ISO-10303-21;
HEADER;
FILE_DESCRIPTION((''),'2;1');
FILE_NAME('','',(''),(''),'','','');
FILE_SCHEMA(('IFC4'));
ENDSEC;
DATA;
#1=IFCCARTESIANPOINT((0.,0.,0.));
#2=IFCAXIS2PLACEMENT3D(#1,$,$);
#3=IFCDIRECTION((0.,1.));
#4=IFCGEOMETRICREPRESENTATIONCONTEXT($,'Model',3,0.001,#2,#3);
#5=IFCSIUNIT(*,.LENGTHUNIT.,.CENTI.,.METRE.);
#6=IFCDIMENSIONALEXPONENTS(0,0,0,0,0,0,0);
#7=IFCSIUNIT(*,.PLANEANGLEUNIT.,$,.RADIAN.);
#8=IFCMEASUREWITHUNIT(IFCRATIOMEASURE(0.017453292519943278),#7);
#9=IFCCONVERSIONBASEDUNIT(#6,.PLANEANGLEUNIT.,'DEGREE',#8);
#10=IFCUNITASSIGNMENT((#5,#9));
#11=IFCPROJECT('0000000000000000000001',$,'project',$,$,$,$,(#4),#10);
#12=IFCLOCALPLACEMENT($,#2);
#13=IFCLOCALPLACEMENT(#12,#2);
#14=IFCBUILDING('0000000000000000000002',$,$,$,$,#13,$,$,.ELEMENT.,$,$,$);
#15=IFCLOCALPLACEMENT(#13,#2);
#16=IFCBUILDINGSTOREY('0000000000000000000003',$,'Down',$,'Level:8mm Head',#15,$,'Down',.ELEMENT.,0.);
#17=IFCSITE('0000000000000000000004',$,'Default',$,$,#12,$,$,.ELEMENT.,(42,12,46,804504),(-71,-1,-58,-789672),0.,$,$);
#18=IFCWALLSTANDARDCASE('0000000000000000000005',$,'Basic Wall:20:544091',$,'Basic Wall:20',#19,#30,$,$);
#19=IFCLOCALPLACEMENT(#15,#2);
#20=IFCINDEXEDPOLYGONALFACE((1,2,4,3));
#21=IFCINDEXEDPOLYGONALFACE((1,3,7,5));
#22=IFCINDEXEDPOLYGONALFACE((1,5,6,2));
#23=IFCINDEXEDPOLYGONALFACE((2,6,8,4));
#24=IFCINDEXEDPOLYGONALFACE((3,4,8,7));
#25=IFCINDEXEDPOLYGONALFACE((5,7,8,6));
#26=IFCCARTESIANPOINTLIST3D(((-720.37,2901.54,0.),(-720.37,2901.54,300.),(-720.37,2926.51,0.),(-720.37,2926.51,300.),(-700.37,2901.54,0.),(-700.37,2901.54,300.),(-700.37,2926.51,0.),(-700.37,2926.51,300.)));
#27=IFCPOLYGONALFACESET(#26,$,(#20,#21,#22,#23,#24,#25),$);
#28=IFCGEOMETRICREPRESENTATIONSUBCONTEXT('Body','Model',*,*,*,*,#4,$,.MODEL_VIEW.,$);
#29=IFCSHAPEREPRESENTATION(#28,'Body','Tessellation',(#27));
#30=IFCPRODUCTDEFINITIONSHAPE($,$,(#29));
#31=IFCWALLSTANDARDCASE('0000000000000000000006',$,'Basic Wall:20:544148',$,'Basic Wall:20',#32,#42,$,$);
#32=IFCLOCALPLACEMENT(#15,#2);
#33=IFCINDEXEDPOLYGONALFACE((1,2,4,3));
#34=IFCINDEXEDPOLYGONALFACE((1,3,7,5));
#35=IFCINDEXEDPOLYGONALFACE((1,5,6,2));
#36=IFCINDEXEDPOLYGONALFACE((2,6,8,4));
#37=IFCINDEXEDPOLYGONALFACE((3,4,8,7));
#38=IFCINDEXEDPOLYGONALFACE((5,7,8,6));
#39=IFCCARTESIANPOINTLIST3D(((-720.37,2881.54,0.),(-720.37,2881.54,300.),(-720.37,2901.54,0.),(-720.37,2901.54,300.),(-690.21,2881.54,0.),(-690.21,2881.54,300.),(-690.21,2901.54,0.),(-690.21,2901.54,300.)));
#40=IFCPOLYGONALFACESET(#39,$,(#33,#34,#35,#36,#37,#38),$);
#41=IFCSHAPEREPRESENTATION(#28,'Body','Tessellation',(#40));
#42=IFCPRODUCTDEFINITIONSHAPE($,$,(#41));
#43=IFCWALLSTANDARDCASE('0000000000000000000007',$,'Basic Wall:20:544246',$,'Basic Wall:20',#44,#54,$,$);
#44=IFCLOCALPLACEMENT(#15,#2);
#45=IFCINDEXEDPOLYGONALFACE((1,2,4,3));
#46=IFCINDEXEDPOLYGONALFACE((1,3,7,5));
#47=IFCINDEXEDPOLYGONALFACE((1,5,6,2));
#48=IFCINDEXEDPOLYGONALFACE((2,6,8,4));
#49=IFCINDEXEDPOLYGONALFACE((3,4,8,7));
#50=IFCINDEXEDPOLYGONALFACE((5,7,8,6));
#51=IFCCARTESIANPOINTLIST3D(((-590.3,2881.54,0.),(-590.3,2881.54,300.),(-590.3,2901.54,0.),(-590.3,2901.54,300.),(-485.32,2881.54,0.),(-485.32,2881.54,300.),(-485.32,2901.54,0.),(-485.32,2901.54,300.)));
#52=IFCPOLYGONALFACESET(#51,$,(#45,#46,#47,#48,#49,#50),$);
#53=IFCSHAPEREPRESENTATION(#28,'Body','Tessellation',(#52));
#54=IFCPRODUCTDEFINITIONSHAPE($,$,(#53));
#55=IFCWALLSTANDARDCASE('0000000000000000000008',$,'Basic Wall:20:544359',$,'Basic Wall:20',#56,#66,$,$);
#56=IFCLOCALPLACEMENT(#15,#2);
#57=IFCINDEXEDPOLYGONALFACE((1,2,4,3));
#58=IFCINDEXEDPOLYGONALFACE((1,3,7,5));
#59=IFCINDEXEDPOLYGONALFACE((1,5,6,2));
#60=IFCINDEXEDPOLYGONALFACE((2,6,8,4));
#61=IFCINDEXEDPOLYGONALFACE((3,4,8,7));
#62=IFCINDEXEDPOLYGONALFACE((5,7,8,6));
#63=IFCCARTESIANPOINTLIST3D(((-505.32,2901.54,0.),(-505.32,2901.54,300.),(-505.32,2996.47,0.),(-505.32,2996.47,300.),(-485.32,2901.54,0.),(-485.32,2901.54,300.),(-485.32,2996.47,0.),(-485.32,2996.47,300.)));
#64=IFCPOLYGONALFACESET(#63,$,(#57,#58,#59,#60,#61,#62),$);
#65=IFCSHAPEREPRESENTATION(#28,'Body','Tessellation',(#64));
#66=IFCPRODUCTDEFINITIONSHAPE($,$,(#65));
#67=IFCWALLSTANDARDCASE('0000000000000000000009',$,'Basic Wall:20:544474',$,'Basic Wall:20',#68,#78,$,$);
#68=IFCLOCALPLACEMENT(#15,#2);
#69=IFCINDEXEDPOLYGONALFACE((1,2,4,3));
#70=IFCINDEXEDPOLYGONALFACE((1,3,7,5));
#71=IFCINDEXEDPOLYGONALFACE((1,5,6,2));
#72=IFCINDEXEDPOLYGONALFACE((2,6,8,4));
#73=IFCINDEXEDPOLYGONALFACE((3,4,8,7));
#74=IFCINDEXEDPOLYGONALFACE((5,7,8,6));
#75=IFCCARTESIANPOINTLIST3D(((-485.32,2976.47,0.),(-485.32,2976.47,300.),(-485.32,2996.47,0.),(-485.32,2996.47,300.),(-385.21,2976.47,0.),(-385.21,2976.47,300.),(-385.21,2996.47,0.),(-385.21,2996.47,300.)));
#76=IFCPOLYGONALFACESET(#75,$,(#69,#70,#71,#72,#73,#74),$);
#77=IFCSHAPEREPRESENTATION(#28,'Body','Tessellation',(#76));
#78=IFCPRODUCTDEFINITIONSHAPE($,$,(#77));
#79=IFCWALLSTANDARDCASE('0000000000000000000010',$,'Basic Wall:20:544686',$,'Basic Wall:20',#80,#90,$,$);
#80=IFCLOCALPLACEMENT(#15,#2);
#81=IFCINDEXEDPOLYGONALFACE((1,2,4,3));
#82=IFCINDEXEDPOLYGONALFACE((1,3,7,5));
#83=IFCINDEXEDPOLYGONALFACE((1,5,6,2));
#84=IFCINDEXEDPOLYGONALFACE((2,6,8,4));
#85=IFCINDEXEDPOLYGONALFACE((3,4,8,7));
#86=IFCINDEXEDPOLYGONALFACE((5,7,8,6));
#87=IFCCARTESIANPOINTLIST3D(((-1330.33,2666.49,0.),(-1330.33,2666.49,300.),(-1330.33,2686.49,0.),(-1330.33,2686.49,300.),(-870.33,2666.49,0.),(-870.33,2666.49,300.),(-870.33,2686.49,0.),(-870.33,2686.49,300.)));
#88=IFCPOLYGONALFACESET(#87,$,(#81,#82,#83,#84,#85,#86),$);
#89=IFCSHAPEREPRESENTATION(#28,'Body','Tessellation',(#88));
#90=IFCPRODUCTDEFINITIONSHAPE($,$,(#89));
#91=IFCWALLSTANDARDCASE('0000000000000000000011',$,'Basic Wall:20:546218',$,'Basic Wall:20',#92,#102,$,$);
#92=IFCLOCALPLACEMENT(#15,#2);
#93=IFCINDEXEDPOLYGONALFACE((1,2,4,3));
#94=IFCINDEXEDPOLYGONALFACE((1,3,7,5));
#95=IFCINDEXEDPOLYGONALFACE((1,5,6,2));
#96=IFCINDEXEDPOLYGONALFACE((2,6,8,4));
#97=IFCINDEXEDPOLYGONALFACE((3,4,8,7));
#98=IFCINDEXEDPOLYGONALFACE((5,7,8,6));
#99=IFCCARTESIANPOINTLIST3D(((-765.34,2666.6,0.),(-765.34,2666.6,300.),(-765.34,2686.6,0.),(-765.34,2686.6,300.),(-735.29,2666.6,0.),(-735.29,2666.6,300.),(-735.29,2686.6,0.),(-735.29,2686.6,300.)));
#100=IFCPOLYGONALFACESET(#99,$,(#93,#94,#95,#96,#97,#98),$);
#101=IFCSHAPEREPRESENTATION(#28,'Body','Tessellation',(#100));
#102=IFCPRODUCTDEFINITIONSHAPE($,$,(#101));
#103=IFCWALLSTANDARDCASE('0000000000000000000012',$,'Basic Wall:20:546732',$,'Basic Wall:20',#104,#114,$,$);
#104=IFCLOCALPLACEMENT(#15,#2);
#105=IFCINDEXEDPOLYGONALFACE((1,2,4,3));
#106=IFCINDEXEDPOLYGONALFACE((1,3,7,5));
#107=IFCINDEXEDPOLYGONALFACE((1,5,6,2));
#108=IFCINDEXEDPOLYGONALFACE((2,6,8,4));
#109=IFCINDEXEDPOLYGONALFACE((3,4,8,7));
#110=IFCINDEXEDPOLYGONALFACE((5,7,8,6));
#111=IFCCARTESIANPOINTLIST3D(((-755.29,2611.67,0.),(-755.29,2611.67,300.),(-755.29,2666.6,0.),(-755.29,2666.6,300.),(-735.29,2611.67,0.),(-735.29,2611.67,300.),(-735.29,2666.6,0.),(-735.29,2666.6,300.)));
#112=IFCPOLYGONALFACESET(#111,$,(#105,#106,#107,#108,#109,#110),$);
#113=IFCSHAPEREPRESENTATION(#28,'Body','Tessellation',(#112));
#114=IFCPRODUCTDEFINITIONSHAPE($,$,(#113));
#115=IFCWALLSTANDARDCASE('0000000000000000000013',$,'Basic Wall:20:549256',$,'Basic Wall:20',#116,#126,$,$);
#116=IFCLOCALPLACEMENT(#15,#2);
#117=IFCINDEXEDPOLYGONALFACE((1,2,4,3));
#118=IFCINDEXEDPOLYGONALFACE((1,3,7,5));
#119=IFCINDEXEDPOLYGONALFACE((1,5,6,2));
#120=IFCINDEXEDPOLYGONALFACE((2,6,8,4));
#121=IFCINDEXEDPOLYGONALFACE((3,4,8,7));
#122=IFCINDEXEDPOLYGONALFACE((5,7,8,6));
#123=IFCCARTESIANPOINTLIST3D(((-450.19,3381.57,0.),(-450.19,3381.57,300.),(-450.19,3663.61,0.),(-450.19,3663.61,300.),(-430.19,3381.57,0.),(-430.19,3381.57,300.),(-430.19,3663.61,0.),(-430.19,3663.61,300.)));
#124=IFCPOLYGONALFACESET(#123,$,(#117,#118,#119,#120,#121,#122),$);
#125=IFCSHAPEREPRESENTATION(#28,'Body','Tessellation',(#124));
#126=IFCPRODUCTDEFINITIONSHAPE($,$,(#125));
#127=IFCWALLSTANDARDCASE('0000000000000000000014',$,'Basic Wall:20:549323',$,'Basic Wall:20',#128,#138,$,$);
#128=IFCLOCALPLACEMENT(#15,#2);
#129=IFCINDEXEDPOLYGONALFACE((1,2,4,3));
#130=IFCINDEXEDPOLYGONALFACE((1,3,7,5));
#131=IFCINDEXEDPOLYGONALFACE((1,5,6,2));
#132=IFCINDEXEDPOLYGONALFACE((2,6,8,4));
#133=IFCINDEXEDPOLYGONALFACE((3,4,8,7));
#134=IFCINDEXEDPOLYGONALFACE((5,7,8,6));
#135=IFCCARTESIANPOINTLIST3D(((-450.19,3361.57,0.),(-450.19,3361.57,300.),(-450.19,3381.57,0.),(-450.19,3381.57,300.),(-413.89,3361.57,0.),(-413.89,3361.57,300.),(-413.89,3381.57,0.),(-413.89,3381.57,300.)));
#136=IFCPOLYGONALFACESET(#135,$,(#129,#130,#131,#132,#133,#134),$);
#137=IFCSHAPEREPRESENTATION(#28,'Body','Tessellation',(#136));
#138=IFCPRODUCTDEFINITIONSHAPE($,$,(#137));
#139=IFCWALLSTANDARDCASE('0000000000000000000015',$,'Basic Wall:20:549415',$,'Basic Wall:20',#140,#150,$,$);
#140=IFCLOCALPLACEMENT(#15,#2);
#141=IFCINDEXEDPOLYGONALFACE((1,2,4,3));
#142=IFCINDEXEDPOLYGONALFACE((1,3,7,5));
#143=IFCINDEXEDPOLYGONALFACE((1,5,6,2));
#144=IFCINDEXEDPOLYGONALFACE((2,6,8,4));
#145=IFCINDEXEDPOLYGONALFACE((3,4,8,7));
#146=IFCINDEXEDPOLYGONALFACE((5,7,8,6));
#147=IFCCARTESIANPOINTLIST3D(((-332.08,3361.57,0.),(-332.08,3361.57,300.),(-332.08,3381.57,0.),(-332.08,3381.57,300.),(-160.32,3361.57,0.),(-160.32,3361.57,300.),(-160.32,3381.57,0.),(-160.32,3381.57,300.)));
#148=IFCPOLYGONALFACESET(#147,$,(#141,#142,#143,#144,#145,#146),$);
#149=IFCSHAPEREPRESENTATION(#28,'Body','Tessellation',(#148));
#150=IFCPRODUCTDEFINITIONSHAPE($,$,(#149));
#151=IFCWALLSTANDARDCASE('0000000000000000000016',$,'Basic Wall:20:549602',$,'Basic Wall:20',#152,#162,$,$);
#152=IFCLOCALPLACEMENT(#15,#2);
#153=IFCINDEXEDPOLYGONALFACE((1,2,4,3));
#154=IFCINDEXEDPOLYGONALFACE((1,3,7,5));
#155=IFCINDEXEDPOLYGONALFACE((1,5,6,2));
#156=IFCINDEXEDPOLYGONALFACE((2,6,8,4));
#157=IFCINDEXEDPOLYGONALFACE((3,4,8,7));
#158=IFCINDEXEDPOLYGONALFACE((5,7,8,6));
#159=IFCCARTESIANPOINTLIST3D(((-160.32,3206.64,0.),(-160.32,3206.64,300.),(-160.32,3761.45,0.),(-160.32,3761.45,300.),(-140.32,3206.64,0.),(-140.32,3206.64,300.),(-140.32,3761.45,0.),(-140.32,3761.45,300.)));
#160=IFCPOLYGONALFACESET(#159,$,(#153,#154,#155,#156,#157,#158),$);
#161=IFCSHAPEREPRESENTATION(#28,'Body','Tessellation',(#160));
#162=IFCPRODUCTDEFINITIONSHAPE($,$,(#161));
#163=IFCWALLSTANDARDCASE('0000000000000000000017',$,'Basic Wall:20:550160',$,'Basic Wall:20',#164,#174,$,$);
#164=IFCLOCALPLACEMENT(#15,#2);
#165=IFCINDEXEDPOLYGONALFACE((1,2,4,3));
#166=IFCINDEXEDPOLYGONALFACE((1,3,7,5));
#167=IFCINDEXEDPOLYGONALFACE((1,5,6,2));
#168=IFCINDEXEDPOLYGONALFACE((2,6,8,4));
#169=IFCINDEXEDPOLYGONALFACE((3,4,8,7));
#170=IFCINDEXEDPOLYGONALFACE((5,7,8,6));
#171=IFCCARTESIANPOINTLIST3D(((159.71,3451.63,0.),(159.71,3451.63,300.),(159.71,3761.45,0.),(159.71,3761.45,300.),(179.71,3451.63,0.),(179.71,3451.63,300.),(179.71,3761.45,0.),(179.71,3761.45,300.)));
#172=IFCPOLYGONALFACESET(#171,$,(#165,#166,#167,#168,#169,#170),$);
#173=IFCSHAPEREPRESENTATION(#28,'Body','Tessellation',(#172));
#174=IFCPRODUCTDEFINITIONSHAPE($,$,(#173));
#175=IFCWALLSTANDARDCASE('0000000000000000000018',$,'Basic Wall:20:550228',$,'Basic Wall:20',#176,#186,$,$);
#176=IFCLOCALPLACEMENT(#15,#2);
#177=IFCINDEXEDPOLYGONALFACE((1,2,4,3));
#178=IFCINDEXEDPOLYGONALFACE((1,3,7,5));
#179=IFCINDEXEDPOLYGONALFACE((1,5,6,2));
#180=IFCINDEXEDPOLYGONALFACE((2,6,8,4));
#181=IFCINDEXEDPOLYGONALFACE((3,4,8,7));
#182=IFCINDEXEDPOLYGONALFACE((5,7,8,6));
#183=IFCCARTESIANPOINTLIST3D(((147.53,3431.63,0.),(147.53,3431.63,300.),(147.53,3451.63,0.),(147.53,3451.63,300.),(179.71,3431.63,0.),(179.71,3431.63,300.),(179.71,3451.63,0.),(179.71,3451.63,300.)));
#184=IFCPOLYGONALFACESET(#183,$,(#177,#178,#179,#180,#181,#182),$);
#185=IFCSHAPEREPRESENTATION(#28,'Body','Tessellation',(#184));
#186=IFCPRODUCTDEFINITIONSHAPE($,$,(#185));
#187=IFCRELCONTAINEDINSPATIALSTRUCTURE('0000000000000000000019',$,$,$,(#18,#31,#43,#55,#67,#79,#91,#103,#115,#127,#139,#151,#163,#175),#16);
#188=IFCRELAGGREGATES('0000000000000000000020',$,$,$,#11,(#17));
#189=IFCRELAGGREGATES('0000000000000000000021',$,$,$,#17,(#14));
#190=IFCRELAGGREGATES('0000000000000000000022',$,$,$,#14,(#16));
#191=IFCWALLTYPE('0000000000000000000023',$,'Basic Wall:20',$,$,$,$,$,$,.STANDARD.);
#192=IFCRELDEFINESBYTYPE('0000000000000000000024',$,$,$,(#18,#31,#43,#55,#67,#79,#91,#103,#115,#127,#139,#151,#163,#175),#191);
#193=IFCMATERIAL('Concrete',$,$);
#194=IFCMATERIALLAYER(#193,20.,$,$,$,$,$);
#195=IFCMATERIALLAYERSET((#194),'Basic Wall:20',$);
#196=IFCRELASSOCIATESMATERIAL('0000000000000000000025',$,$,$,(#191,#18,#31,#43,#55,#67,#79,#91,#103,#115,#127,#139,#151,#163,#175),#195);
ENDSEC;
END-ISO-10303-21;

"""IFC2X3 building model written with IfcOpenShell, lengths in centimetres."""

from ifc_helpers import new_model, entity, si_unit, converted_unit, direction, frame, frame_2d, origin, place, context, subcontext, project, spatial, rectangle, extrude, material, layer, layer_set, layer_usage, type_object, element, save


model = new_model("IFC2X3")

# Units and contexts
model_context = context("Model", 3, precision=0.001, world=origin(), true_north=direction((0.0, 1.0)))
body_context = subcontext(model_context, "Body", "Model", "MODEL_VIEW")
ifc_project = project(units=[si_unit("LENGTHUNIT", "METRE", prefix="CENTI"), converted_unit("PLANEANGLEUNIT", "DEGREE", entity("IfcRatioMeasure", 0.017453292519943278), si_unit("PLANEANGLEUNIT", "RADIAN"), dimensions=[0, 0, 0, 0, 0, 0, 0])], contexts=[model_context])

# Site, building, storey
site_placement = place(None, origin())
site = spatial("IfcSite", under=ifc_project, at=site_placement, Name="Default", CompositionType="ELEMENT", RefLatitude=(42, 12, 46, 804504), RefLongitude=(-71, -1, -58, -789672), RefElevation=0.0)
building_placement = place(site_placement, origin())
building = spatial("IfcBuilding", under=site, at=building_placement, CompositionType="ELEMENT")
storey_placement = place(building_placement, origin())
storey = spatial("IfcBuildingStorey", under=building, at=storey_placement, Name="Down", ObjectType="Level:8mm Head", LongName="Down", CompositionType="ELEMENT", Elevation=0.0)

# Walls
ifc_material = material(Name="Concrete")
ifc_layer_1 = layer(ifc_material, 20.0)
ifc_layer_set_1 = layer_set([ifc_layer_1], Name="Basic Wall:20")
ifc_layer_usage_1 = layer_usage(ifc_layer_set_1, "AXIS2", "NEGATIVE", 10.0)
wall_type_1 = type_object("IfcWallType", Name="Basic Wall:20", PredefinedType="STANDARD", material=ifc_layer_set_1)
wall_1_placement = place(storey_placement, frame((-710.37, 2926.51, 0.0), z_axis=(0.0, 0.0, 1.0), x_axis=(0.0, -1.0, 0.0)))
element("IfcWallStandardCase", 1, at=wall_1_placement, inside=storey, type_object=wall_type_1, material=ifc_layer_usage_1, Name="Basic Wall:20:544091", ObjectType="Basic Wall:20", context=body_context, shape_type="SweptSolid", body=[
    extrude(rectangle(XDim=24.98, YDim=20.0, at=frame_2d((12.49, 0.0), x_axis=(-1.0, 0.0))), origin(), (0.0, 0.0, 1.0), 300.0),
])
ifc_layer_usage_2 = layer_usage(ifc_layer_set_1, "AXIS2", "POSITIVE", -10.0)
wall_2_placement = place(storey_placement, frame((-720.37, 2891.54, 0.0)))
element("IfcWallStandardCase", 2, at=wall_2_placement, inside=storey, type_object=wall_type_1, material=ifc_layer_usage_2, Name="Basic Wall:20:544148", ObjectType="Basic Wall:20", context=body_context, shape_type="SweptSolid", body=[
    extrude(rectangle(XDim=30.16, YDim=20.0, at=frame_2d((15.08, 0.0), x_axis=(-1.0, 0.0))), origin(), (0.0, 0.0, 1.0), 300.0),
])
ifc_layer_usage_3 = layer_usage(ifc_layer_set_1, "AXIS2", "POSITIVE", -10.0)
wall_3_placement = place(storey_placement, frame((-590.3, 2891.54, 0.0)))
element("IfcWallStandardCase", 3, at=wall_3_placement, inside=storey, type_object=wall_type_1, material=ifc_layer_usage_3, Name="Basic Wall:20:544246", ObjectType="Basic Wall:20", context=body_context, shape_type="SweptSolid", body=[
    extrude(rectangle(XDim=104.98, YDim=20.0, at=frame_2d((52.49, 0.0), x_axis=(-1.0, 0.0))), origin(), (0.0, 0.0, 1.0), 300.0),
])
ifc_layer_usage_4 = layer_usage(ifc_layer_set_1, "AXIS2", "POSITIVE", -10.0)
wall_4_placement = place(storey_placement, frame((-495.32, 2901.54, 0.0), z_axis=(0.0, 0.0, 1.0), x_axis=(0.0, 1.0, 0.0)))
element("IfcWallStandardCase", 4, at=wall_4_placement, inside=storey, type_object=wall_type_1, material=ifc_layer_usage_4, Name="Basic Wall:20:544359", ObjectType="Basic Wall:20", context=body_context, shape_type="SweptSolid", body=[
    extrude(rectangle(XDim=94.93, YDim=20.0, at=frame_2d((47.47, 0.0), x_axis=(-1.0, 0.0))), origin(), (0.0, 0.0, 1.0), 300.0),
])
ifc_layer_usage_5 = layer_usage(ifc_layer_set_1, "AXIS2", "NEGATIVE", 10.0)
wall_5_placement = place(storey_placement, frame((-485.32, 2986.47, 0.0)))
element("IfcWallStandardCase", 5, at=wall_5_placement, inside=storey, type_object=wall_type_1, material=ifc_layer_usage_5, Name="Basic Wall:20:544474", ObjectType="Basic Wall:20", context=body_context, shape_type="SweptSolid", body=[
    extrude(rectangle(XDim=100.11, YDim=20.0, at=frame_2d((50.06, 0.0), x_axis=(-1.0, 0.0))), origin(), (0.0, 0.0, 1.0), 300.0),
])
ifc_layer_usage_6 = layer_usage(ifc_layer_set_1, "AXIS2", "NEGATIVE", 10.0)
wall_6_placement = place(storey_placement, frame((-870.33, 2676.49, 0.0), z_axis=(0.0, 0.0, 1.0), x_axis=(-1.0, 0.0, 0.0)))
element("IfcWallStandardCase", 6, at=wall_6_placement, inside=storey, type_object=wall_type_1, material=ifc_layer_usage_6, Name="Basic Wall:20:544686", ObjectType="Basic Wall:20", context=body_context, shape_type="SweptSolid", body=[
    extrude(rectangle(XDim=460.0, YDim=20.0, at=frame_2d((230.0, 0.0), x_axis=(-1.0, 0.0))), origin(), (0.0, 0.0, 1.0), 300.0),
])
ifc_layer_usage_7 = layer_usage(ifc_layer_set_1, "AXIS2", "NEGATIVE", 10.0)
wall_7_placement = place(storey_placement, frame((-765.34, 2676.6, 0.0)))
element("IfcWallStandardCase", 7, at=wall_7_placement, inside=storey, type_object=wall_type_1, material=ifc_layer_usage_7, Name="Basic Wall:20:546218", ObjectType="Basic Wall:20", context=body_context, shape_type="SweptSolid", body=[
    extrude(rectangle(XDim=30.06, YDim=20.0, at=frame_2d((15.03, 0.0), x_axis=(-1.0, 0.0))), origin(), (0.0, 0.0, 1.0), 300.0),
])
ifc_layer_usage_8 = layer_usage(ifc_layer_set_1, "AXIS2", "NEGATIVE", 10.0)
wall_8_placement = place(storey_placement, frame((-745.29, 2666.6, 0.0), z_axis=(0.0, 0.0, 1.0), x_axis=(0.0, -1.0, 0.0)))
element("IfcWallStandardCase", 8, at=wall_8_placement, inside=storey, type_object=wall_type_1, material=ifc_layer_usage_8, Name="Basic Wall:20:546732", ObjectType="Basic Wall:20", context=body_context, shape_type="SweptSolid", body=[
    extrude(rectangle(XDim=54.93, YDim=20.0, at=frame_2d((27.46, 0.0), x_axis=(-1.0, 0.0))), origin(), (0.0, 0.0, 1.0), 300.0),
])
ifc_layer_usage_9 = layer_usage(ifc_layer_set_1, "AXIS2", "NEGATIVE", 10.0)
wall_9_placement = place(storey_placement, frame((-440.19, 3381.57, 0.0), z_axis=(0.0, 0.0, 1.0), x_axis=(0.0, 1.0, 0.0)))
element("IfcWallStandardCase", 9, at=wall_9_placement, inside=storey, type_object=wall_type_1, material=ifc_layer_usage_9, Name="Basic Wall:20:549256", ObjectType="Basic Wall:20", context=body_context, shape_type="SweptSolid", body=[
    extrude(rectangle(XDim=282.03, YDim=20.0, at=frame_2d((141.02, 0.0), x_axis=(-1.0, 0.0))), origin(), (0.0, 0.0, 1.0), 300.0),
])
ifc_layer_usage_10 = layer_usage(ifc_layer_set_1, "AXIS2", "POSITIVE", -10.0)
wall_10_placement = place(storey_placement, frame((-450.19, 3371.57, 0.0)))
element("IfcWallStandardCase", 10, at=wall_10_placement, inside=storey, type_object=wall_type_1, material=ifc_layer_usage_10, Name="Basic Wall:20:549323", ObjectType="Basic Wall:20", context=body_context, shape_type="SweptSolid", body=[
    extrude(rectangle(XDim=36.3, YDim=20.0, at=frame_2d((18.15, 0.0), x_axis=(-1.0, 0.0))), origin(), (0.0, 0.0, 1.0), 300.0),
])
ifc_layer_usage_11 = layer_usage(ifc_layer_set_1, "AXIS2", "POSITIVE", -10.0)
wall_11_placement = place(storey_placement, frame((-332.08, 3371.57, 0.0)))
element("IfcWallStandardCase", 11, at=wall_11_placement, inside=storey, type_object=wall_type_1, material=ifc_layer_usage_11, Name="Basic Wall:20:549415", ObjectType="Basic Wall:20", context=body_context, shape_type="SweptSolid", body=[
    extrude(rectangle(XDim=171.76, YDim=20.0, at=frame_2d((85.88, 0.0), x_axis=(-1.0, 0.0))), origin(), (0.0, 0.0, 1.0), 300.0),
])
ifc_layer_usage_12 = layer_usage(ifc_layer_set_1, "AXIS2", "NEGATIVE", 10.0)
wall_12_placement = place(storey_placement, frame((-150.32, 3761.45, 0.0), z_axis=(0.0, 0.0, 1.0), x_axis=(0.0, -1.0, 0.0)))
element("IfcWallStandardCase", 12, at=wall_12_placement, inside=storey, type_object=wall_type_1, material=ifc_layer_usage_12, Name="Basic Wall:20:549602", ObjectType="Basic Wall:20", context=body_context, shape_type="SweptSolid", body=[
    extrude(rectangle(XDim=554.81, YDim=20.0, at=frame_2d((277.4, 0.0), x_axis=(-1.0, 0.0))), origin(), (0.0, 0.0, 1.0), 300.0),
])
ifc_layer_usage_13 = layer_usage(ifc_layer_set_1, "AXIS2", "NEGATIVE", 10.0)
wall_13_placement = place(storey_placement, frame((169.71, 3761.45, 0.0), z_axis=(0.0, 0.0, 1.0), x_axis=(0.0, -1.0, 0.0)))
element("IfcWallStandardCase", 13, at=wall_13_placement, inside=storey, type_object=wall_type_1, material=ifc_layer_usage_13, Name="Basic Wall:20:550160", ObjectType="Basic Wall:20", context=body_context, shape_type="SweptSolid", body=[
    extrude(rectangle(XDim=309.82, YDim=20.0, at=frame_2d((154.91, 0.0), x_axis=(-1.0, 0.0))), origin(), (0.0, 0.0, 1.0), 300.0),
])
ifc_layer_usage_14 = layer_usage(ifc_layer_set_1, "AXIS2", "NEGATIVE", 10.0)
wall_14_placement = place(storey_placement, frame((179.71, 3441.63, 0.0), z_axis=(0.0, 0.0, 1.0), x_axis=(-1.0, 0.0, 0.0)))
element("IfcWallStandardCase", 14, at=wall_14_placement, inside=storey, type_object=wall_type_1, material=ifc_layer_usage_14, Name="Basic Wall:20:550228", ObjectType="Basic Wall:20", context=body_context, shape_type="SweptSolid", body=[
    extrude(rectangle(XDim=32.18, YDim=20.0, at=frame_2d((16.09, 0.0), x_axis=(-1.0, 0.0))), origin(), (0.0, 0.0, 1.0), 300.0),
])

save(model, "model.ifc")
